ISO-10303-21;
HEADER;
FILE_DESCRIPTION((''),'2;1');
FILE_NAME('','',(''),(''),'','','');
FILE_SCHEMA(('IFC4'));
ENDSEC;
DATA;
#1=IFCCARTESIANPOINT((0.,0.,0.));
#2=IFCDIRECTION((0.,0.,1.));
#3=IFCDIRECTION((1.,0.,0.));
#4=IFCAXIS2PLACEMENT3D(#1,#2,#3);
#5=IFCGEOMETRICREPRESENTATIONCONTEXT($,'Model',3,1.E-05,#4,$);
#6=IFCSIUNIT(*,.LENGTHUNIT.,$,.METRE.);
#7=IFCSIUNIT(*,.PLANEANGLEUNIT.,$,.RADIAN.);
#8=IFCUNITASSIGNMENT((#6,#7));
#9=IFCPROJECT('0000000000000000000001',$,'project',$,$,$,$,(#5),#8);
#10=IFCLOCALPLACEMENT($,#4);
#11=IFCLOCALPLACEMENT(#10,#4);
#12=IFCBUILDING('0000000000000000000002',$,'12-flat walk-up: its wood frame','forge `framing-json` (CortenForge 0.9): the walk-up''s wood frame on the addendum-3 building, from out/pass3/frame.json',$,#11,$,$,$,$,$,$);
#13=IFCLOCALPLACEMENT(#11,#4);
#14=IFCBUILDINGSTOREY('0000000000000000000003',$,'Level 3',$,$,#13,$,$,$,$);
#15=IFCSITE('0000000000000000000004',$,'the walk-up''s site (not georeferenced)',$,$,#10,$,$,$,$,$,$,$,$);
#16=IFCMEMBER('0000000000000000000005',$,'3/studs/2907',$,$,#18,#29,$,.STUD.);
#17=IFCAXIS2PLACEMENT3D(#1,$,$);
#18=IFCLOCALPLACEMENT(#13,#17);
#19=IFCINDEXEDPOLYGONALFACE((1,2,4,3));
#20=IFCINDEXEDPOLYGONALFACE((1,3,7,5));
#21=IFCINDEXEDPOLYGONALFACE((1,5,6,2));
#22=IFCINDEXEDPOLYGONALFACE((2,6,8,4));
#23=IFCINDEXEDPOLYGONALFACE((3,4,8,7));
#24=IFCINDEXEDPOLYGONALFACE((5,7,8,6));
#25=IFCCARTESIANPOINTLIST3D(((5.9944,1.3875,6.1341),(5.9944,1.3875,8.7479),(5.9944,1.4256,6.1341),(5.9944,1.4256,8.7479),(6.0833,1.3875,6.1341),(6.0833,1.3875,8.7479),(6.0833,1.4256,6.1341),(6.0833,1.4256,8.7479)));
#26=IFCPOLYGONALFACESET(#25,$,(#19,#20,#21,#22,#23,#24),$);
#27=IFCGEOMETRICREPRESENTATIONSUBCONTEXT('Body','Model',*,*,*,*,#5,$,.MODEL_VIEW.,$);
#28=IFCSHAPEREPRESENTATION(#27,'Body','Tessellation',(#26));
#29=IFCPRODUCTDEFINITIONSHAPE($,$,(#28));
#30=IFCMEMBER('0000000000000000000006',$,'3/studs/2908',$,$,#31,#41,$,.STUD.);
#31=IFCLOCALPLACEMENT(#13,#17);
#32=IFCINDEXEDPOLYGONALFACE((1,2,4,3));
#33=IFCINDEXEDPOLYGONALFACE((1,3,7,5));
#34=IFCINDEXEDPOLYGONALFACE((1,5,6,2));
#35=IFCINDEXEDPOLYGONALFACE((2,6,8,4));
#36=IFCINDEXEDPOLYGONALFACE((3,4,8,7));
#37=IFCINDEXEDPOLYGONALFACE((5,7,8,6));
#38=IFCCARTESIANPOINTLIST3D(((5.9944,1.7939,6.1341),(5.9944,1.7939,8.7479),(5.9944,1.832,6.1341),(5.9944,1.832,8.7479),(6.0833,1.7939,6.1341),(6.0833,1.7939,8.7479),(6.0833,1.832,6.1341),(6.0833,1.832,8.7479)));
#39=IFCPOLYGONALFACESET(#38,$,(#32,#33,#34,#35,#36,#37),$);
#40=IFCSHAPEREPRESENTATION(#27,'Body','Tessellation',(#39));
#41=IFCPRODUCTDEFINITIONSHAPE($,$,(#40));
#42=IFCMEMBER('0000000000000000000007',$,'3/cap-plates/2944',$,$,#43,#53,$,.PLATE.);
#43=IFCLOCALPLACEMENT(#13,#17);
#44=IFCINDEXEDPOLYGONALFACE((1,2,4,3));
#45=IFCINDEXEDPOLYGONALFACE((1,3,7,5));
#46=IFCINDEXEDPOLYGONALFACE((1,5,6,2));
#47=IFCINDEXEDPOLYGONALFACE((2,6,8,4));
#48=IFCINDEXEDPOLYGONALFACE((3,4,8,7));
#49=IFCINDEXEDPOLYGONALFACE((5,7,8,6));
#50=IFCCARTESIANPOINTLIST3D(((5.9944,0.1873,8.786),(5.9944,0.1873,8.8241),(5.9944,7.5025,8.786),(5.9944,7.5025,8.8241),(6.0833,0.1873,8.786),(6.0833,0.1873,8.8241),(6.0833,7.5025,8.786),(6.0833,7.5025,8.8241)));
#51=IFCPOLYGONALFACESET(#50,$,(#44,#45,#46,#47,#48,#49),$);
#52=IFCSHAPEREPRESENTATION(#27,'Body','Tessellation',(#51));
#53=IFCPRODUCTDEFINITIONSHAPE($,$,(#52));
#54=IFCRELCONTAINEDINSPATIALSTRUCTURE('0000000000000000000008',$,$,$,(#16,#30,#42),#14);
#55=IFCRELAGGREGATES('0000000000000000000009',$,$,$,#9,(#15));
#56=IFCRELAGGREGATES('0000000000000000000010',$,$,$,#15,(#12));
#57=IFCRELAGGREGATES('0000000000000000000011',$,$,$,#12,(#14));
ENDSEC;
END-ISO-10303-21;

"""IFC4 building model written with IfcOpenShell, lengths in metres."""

from ifc_helpers import new_model, si_unit, frame, frame_2d, origin, origin_with_axes, place, context, subcontext, project, spatial, rectangle, extrude, element, save


model = new_model("IFC4")

# Units and contexts
model_context = context("Model", 3, precision=1e-05, world=origin_with_axes())
body_context = subcontext(model_context, "Body", "Model", "MODEL_VIEW")
ifc_project = project(units=[si_unit("LENGTHUNIT", "METRE"), si_unit("PLANEANGLEUNIT", "RADIAN")], contexts=[model_context])

# Site, building, storey
site_placement = place(None, origin_with_axes())
site = spatial("IfcSite", under=ifc_project, at=site_placement, Name="the walk-up's site (not georeferenced)")
building_placement = place(site_placement, origin_with_axes())
building = spatial("IfcBuilding", under=site, at=building_placement, Name="12-flat walk-up: its wood frame", Description="forge `framing-json` (CortenForge 0.9): the walk-up's wood frame on the addendum-3 building, from out/pass3/frame.json")
storey_placement = place(building_placement, origin_with_axes())
storey = spatial("IfcBuildingStorey", under=building, at=storey_placement, Name="Level 3")

# Members
member_1_placement = place(storey_placement, frame((5.9944, 1.3875, 6.1341), z_axis=(0.0, 0.0, 1.0), x_axis=(1.0, 0.0, 0.0)))
element("IfcMember", 1, at=member_1_placement, inside=storey, Name="3/studs/2907", PredefinedType="STUD", context=body_context, shape_type="SweptSolid", body=[
    extrude(rectangle(XDim=0.0889, YDim=0.0381, at=frame_2d((0.0445, 0.0191))), origin(), (0.0, 0.0, 1.0), 2.6138),
])
member_2_placement = place(storey_placement, frame((5.9944, 1.7939, 6.1341), z_axis=(0.0, 0.0, 1.0), x_axis=(1.0, 0.0, 0.0)))
element("IfcMember", 2, at=member_2_placement, inside=storey, Name="3/studs/2908", PredefinedType="STUD", context=body_context, shape_type="SweptSolid", body=[
    extrude(rectangle(XDim=0.0889, YDim=0.0381, at=frame_2d((0.0445, 0.019))), origin(), (0.0, 0.0, 1.0), 2.6138),
])
member_3_placement = place(storey_placement, frame((5.9944, 0.1873, 8.786), z_axis=(0.0, 0.0, 1.0), x_axis=(1.0, 0.0, 0.0)))
element("IfcMember", 3, at=member_3_placement, inside=storey, Name="3/cap-plates/2944", PredefinedType="PLATE", context=body_context, shape_type="SweptSolid", body=[
    extrude(rectangle(XDim=0.0889, YDim=7.3152, at=frame_2d((0.0445, 3.6576))), origin(), (0.0, 0.0, 1.0), 0.0381),
])

save(model, "model.ifc")
